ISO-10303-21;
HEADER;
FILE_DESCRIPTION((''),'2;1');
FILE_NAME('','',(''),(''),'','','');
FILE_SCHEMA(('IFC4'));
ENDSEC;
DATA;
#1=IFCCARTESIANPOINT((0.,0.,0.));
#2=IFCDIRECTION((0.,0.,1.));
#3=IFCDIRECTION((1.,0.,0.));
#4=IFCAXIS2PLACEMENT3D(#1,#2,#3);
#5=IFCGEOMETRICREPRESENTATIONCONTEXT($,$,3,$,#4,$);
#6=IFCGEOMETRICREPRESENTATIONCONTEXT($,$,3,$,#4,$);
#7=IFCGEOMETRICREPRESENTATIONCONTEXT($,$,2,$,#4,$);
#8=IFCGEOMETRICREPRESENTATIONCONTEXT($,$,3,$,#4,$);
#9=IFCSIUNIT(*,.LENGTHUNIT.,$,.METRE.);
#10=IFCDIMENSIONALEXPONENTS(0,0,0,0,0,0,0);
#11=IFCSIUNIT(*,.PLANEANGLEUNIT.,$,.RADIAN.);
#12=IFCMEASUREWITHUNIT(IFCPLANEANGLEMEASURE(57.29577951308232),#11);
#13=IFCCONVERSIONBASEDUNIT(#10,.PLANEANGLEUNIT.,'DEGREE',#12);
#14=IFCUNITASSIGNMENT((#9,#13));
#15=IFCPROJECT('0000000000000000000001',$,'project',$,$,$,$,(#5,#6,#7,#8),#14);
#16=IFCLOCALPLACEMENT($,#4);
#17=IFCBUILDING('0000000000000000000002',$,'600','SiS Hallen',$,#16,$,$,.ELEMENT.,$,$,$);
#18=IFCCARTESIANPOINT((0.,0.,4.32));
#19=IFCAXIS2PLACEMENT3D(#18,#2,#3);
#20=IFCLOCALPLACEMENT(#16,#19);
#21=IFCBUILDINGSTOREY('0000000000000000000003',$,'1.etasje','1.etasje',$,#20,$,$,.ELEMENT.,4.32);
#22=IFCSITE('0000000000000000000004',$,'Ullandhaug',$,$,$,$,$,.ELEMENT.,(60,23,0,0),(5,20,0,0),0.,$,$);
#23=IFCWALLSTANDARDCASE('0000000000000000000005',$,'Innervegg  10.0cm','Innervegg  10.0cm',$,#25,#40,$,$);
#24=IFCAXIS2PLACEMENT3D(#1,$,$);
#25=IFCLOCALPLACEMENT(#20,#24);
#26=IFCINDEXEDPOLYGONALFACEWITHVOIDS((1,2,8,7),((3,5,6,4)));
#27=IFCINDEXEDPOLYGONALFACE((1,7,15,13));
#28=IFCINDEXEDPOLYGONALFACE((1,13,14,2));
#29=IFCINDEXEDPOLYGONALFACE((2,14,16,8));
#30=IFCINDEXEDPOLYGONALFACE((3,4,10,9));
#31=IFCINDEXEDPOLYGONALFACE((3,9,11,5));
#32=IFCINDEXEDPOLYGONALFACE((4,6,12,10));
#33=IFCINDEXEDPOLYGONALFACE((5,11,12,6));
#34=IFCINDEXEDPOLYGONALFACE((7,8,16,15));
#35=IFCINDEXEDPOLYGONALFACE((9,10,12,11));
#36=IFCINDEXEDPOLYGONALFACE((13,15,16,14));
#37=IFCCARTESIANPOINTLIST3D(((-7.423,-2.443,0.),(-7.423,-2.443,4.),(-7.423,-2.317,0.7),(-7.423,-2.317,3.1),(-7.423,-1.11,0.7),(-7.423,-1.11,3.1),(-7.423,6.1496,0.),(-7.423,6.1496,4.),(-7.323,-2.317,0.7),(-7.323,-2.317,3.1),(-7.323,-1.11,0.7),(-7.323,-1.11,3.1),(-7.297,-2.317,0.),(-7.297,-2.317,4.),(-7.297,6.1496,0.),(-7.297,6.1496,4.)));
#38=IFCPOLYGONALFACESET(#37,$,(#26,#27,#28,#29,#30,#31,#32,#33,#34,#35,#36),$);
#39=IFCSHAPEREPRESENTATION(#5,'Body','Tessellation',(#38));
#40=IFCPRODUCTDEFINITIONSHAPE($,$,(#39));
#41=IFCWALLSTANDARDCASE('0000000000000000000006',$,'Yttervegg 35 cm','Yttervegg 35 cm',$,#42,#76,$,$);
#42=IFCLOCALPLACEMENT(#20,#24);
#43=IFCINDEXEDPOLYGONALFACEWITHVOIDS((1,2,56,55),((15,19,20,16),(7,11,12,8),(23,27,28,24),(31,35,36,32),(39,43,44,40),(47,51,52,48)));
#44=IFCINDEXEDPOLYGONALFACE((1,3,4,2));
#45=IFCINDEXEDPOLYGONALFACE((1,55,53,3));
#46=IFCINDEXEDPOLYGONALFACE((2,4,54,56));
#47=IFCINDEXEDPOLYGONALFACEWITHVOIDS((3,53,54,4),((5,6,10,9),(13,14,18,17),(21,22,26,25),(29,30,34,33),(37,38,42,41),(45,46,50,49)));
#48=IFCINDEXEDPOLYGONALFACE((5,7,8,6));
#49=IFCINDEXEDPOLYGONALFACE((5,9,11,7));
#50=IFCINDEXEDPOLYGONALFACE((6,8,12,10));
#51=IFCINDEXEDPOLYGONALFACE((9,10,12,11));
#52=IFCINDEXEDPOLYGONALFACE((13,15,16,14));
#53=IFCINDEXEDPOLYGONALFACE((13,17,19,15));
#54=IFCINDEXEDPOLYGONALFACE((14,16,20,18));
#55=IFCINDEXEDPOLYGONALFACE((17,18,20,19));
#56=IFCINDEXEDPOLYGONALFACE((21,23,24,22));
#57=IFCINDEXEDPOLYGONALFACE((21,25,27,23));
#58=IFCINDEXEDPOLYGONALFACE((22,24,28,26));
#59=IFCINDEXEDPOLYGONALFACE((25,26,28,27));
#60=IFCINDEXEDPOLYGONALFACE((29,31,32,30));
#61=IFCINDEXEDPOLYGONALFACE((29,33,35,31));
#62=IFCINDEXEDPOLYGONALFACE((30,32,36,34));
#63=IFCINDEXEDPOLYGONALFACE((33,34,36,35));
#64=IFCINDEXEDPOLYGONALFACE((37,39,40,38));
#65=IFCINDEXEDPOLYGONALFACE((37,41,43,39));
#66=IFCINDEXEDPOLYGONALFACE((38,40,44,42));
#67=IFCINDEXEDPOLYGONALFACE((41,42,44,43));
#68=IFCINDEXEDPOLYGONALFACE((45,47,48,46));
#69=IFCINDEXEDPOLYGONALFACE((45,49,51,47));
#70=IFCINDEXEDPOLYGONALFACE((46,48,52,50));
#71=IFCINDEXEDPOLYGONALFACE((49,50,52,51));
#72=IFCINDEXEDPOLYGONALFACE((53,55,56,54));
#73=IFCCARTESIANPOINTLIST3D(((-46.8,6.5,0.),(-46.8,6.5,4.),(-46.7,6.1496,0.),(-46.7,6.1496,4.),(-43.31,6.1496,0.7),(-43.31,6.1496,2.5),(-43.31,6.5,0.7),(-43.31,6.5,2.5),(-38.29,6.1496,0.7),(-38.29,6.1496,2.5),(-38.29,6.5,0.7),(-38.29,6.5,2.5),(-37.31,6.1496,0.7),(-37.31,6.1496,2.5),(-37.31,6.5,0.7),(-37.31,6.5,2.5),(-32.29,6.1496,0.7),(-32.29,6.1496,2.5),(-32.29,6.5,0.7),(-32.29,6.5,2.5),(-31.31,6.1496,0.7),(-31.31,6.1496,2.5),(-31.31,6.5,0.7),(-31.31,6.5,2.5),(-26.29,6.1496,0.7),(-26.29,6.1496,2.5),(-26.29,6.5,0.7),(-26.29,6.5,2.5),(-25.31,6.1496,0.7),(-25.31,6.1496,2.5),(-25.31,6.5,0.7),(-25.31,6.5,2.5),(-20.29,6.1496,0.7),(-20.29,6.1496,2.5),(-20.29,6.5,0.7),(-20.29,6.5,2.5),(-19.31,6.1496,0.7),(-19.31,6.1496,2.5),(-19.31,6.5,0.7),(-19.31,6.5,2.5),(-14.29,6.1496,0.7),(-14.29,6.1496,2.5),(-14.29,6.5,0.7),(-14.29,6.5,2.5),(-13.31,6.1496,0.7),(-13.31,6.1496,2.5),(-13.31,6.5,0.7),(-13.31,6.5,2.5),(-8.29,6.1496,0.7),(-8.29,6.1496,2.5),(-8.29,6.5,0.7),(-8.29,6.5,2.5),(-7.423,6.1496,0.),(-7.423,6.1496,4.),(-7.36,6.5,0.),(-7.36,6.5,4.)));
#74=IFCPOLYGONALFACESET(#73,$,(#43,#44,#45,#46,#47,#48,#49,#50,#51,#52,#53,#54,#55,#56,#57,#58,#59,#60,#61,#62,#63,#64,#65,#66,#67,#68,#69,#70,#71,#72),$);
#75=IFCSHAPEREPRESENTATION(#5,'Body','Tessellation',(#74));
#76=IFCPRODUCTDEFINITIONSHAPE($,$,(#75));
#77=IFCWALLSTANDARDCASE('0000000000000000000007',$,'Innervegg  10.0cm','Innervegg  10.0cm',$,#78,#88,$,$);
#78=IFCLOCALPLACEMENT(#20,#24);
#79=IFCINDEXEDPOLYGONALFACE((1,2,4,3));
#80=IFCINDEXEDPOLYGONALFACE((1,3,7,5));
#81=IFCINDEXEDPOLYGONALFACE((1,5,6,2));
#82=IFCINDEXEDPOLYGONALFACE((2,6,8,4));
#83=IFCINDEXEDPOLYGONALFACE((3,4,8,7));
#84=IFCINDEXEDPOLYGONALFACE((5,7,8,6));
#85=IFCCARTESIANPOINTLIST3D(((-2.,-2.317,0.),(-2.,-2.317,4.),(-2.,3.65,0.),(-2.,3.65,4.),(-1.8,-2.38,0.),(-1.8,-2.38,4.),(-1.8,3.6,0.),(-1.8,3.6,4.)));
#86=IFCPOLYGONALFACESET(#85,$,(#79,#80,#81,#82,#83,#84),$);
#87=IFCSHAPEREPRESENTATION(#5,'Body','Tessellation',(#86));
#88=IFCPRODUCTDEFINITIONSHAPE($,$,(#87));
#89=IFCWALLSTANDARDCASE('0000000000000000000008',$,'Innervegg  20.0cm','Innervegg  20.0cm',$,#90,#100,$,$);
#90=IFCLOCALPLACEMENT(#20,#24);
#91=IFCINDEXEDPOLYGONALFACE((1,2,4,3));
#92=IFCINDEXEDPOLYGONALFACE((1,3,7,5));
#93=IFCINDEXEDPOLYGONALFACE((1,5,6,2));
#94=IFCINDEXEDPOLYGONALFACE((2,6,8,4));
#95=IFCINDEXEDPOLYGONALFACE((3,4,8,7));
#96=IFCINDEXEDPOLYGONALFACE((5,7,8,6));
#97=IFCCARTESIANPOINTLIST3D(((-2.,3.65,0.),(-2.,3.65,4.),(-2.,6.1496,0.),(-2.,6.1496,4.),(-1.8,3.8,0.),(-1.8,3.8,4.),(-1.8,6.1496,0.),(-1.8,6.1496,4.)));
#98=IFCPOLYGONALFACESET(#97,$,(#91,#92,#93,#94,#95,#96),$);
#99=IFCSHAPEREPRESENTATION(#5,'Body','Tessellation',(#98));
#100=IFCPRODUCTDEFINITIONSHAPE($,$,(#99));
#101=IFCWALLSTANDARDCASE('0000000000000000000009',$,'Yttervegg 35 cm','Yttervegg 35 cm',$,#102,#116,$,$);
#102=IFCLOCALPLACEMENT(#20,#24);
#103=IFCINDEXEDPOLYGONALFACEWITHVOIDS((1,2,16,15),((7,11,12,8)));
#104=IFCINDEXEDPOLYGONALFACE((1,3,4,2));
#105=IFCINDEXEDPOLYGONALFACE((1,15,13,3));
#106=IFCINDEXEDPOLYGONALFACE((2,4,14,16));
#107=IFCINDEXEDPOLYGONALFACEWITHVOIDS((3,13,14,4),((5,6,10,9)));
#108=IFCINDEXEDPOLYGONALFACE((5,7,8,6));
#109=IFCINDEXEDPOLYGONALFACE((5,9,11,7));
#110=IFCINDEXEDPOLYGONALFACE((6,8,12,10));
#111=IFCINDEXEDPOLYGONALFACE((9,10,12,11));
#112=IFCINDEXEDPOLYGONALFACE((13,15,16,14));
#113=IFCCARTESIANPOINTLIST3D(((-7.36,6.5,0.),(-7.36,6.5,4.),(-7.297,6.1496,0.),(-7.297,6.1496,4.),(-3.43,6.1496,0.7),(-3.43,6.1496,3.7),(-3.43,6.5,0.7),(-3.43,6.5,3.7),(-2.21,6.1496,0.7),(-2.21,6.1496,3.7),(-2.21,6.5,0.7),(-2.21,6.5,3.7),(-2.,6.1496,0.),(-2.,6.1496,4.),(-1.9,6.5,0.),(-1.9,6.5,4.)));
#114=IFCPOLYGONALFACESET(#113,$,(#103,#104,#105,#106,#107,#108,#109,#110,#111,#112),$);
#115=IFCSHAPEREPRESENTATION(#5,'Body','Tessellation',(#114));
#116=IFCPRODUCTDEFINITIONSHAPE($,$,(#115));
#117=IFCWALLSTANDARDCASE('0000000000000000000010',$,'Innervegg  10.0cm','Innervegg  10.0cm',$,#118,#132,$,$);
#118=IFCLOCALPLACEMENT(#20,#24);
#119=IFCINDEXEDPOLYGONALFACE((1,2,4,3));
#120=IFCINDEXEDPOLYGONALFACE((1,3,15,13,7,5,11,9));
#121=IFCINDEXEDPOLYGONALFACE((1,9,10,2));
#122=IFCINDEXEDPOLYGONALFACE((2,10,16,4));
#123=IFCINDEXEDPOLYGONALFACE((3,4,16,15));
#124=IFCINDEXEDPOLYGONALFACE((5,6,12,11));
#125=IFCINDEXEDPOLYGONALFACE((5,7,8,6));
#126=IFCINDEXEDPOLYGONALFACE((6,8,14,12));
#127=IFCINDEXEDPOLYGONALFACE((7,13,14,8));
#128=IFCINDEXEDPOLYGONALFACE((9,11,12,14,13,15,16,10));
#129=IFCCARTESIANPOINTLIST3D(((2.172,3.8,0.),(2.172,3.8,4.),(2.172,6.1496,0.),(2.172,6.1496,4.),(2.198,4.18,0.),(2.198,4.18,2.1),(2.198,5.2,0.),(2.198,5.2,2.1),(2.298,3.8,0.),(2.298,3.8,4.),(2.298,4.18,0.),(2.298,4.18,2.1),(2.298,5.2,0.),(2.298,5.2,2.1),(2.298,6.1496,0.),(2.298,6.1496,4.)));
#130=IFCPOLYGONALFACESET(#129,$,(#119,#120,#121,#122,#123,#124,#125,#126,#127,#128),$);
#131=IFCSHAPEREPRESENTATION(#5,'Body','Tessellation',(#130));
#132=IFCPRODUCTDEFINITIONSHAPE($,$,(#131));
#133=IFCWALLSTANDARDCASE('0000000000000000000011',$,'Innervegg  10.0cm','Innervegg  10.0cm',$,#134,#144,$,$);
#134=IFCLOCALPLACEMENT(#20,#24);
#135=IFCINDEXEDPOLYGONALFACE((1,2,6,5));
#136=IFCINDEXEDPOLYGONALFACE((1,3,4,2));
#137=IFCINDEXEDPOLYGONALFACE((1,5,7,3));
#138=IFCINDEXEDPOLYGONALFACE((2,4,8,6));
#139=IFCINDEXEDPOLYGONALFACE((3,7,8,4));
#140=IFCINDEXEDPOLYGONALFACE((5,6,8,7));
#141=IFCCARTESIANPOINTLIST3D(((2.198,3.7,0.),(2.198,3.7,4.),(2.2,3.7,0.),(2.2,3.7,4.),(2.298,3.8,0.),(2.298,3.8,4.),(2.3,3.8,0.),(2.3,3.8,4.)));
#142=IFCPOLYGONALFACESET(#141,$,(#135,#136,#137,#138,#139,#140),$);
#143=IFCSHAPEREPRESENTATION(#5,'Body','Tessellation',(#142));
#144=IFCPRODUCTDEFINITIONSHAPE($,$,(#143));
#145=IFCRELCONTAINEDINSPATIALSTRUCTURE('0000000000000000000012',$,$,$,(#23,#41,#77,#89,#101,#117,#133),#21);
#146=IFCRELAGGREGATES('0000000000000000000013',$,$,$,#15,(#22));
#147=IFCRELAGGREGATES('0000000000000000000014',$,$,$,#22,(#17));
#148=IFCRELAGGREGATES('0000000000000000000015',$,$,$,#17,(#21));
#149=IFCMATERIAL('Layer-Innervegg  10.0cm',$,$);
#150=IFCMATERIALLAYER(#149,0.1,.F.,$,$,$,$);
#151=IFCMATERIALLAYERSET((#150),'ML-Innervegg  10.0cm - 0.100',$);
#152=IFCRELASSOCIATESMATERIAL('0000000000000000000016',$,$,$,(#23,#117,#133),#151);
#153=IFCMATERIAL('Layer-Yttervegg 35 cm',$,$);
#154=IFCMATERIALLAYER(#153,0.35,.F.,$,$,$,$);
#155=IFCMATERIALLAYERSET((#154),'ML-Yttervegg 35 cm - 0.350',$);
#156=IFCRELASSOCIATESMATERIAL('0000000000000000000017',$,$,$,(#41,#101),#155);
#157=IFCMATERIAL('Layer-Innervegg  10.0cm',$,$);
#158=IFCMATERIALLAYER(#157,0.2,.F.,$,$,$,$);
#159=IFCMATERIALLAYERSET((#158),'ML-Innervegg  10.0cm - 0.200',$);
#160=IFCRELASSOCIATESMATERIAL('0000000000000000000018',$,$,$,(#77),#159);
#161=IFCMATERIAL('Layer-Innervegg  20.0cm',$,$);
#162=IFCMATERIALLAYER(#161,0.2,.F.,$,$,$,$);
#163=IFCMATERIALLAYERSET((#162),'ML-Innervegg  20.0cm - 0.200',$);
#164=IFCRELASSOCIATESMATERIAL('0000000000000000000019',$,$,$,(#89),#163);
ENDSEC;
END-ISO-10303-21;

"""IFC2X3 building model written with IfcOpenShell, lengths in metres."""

from ifc_helpers import new_model, entity, si_unit, converted_unit, frame, origin_with_axes, place, context, project, spatial, polyline, outline, extrude, material, layer, layer_set, layer_usage, element, save


model = new_model("IFC2X3")

# Units and contexts
context_of_model_1 = context(None, 3, world=origin_with_axes())
context_of_model_2 = context(None, 3, world=origin_with_axes())
context_of_model_3 = context(None, 2, world=origin_with_axes())
context_of_model_4 = context(None, 3, world=origin_with_axes())
ifc_project = project(units=[si_unit("LENGTHUNIT", "METRE"), converted_unit("PLANEANGLEUNIT", "DEGREE", entity("IfcPlaneAngleMeasure", 57.29577951308232), si_unit("PLANEANGLEUNIT", "RADIAN"), dimensions=[0, 0, 0, 0, 0, 0, 0])], contexts=[context_of_model_1, context_of_model_2, context_of_model_3, context_of_model_4])

# Site, building, storey
site = spatial("IfcSite", under=ifc_project, Name="Ullandhaug", CompositionType="ELEMENT", RefLatitude=(60, 23, 0, 0), RefLongitude=(5, 20, 0, 0), RefElevation=0.0)
building_placement = place(None, origin_with_axes())
building = spatial("IfcBuilding", under=site, at=building_placement, Name="600", Description="SiS Hallen", CompositionType="ELEMENT")
storey_placement = place(building_placement, frame((0.0, 0.0, 4.32), z_axis=(0.0, 0.0, 1.0), x_axis=(1.0, 0.0, 0.0)))
storey = spatial("IfcBuildingStorey", under=building, at=storey_placement, Name="1.etasje", Description="1.etasje", CompositionType="ELEMENT", Elevation=4.32)

# Shared definitions
ifc_material_1 = material(Name="Layer-Innervegg  20.0cm")
ifc_layer_1 = layer(ifc_material_1, 0.2, ventilated=False)
ifc_layer_set_1 = layer_set([ifc_layer_1], Name="ML-Innervegg  20.0cm - 0.200")
ifc_layer_usage_1 = layer_usage(ifc_layer_set_1, "AXIS2", "POSITIVE", 0.0)

# Wall, opening
ifc_material_2 = material(Name="Layer-Innervegg  10.0cm")
ifc_layer_2 = layer(ifc_material_2, 0.1, ventilated=False)
ifc_layer_set_2 = layer_set([ifc_layer_2], Name="ML-Innervegg  10.0cm - 0.100")
ifc_layer_usage_2 = layer_usage(ifc_layer_set_2, "AXIS2", "POSITIVE", 0.0)
wall_1_placement = place(storey_placement, frame((-7.297, -2.317, 0.0), z_axis=(0.0, 0.0, 1.0), x_axis=(0.0, 1.0, 0.0)))
wall_1 = element("IfcWallStandardCase", 1, at=wall_1_placement, inside=storey, material=ifc_layer_usage_2, Name="Innervegg  10.0cm", Description="Innervegg  10.0cm", context=context_of_model_1, shape_type="SweptSolid", body=[
    extrude(outline(polyline([(0.0, 0.0), (8.4666, 0.0), (8.4666, 0.126), (-0.126, 0.126), (0.0, 0.0)])), frame((0.0, 0.0, 0.0), z_axis=(0.0, 0.0, 1.0), x_axis=(1.0, 0.0, 0.0)), (0.0, 0.0, 1.0), 4.0),
])
opening_1_placement = place(wall_1_placement, frame((0.0, 0.126, 0.7), z_axis=(0.0, 0.0, 1.0), x_axis=(1.0, 0.0, 0.0)))
element("IfcOpeningElement", 2, at=opening_1_placement, cuts=wall_1, context=context_of_model_1, shape_type="SweptSolid", body=[
    extrude(outline(polyline([(0.0, 0.0), (2.4, 0.0), (2.4, 1.207), (0.0, 1.207), (0.0, 0.0)])), frame((0.0, 0.0, 0.0), z_axis=(0.0, 1.0, 0.0), x_axis=(0.0, 0.0, 1.0)), (0.0, 0.0, -1.0), 0.1),
])

# Wall, openings
ifc_material_3 = material(Name="Layer-Yttervegg 35 cm")
ifc_layer_3 = layer(ifc_material_3, 0.35, ventilated=False)
ifc_layer_set_3 = layer_set([ifc_layer_3], Name="ML-Yttervegg 35 cm - 0.350")
ifc_layer_usage_3 = layer_usage(ifc_layer_set_3, "AXIS2", "POSITIVE", 0.0)
wall_2_placement = place(storey_placement, frame((-7.36, 6.5, 0.0), z_axis=(0.0, 0.0, 1.0), x_axis=(-1.0, 0.0, 0.0)))
wall_2 = element("IfcWallStandardCase", 3, at=wall_2_placement, inside=storey, material=ifc_layer_usage_3, Name="Yttervegg 35 cm", Description="Yttervegg 35 cm", context=context_of_model_1, shape_type="SweptSolid", body=[
    extrude(outline(polyline([(0.0, 0.0), (39.44, 0.0), (39.34, 0.3504), (0.063, 0.3504), (0.0, 0.0)])), frame((0.0, 0.0, 0.0), z_axis=(0.0, 0.0, 1.0), x_axis=(1.0, 0.0, 0.0)), (0.0, 0.0, 1.0), 4.0),
])
opening_2_placement = place(wall_2_placement, frame((0.93, 0.3504, 0.7), z_axis=(0.0, 0.0, 1.0), x_axis=(1.0, 0.0, 0.0)))
element("IfcOpeningElement", 4, at=opening_2_placement, cuts=wall_2, context=context_of_model_1, shape_type="SweptSolid", body=[
    extrude(outline(polyline([(0.0, 0.0), (1.8, 0.0), (1.8, 5.02), (0.0, 5.02), (0.0, 0.0)])), frame((0.0, 0.0, 0.0), z_axis=(0.0, 1.0, 0.0), x_axis=(0.0, 0.0, 1.0)), (0.0, 0.0, -1.0), 0.3504),
])
opening_3_placement = place(wall_2_placement, frame((6.93, 0.3504, 0.7), z_axis=(0.0, 0.0, 1.0), x_axis=(1.0, 0.0, 0.0)))
element("IfcOpeningElement", 5, at=opening_3_placement, cuts=wall_2, context=context_of_model_1, shape_type="SweptSolid", body=[
    extrude(outline(polyline([(0.0, 0.0), (1.8, 0.0), (1.8, 5.02), (0.0, 5.02), (0.0, 0.0)])), frame((0.0, 0.0, 0.0), z_axis=(0.0, 1.0, 0.0), x_axis=(0.0, 0.0, 1.0)), (0.0, 0.0, -1.0), 0.3504),
])
opening_4_placement = place(wall_2_placement, frame((12.93, 0.3504, 0.7), z_axis=(0.0, 0.0, 1.0), x_axis=(1.0, 0.0, 0.0)))
element("IfcOpeningElement", 6, at=opening_4_placement, cuts=wall_2, context=context_of_model_1, shape_type="SweptSolid", body=[
    extrude(outline(polyline([(0.0, 0.0), (1.8, 0.0), (1.8, 5.02), (0.0, 5.02), (0.0, 0.0)])), frame((0.0, 0.0, 0.0), z_axis=(0.0, 1.0, 0.0), x_axis=(0.0, 0.0, 1.0)), (0.0, 0.0, -1.0), 0.3504),
])
opening_5_placement = place(wall_2_placement, frame((18.93, 0.3504, 0.7), z_axis=(0.0, 0.0, 1.0), x_axis=(1.0, 0.0, 0.0)))
element("IfcOpeningElement", 7, at=opening_5_placement, cuts=wall_2, context=context_of_model_1, shape_type="SweptSolid", body=[
    extrude(outline(polyline([(0.0, 0.0), (1.8, 0.0), (1.8, 5.02), (0.0, 5.02), (0.0, 0.0)])), frame((0.0, 0.0, 0.0), z_axis=(0.0, 1.0, 0.0), x_axis=(0.0, 0.0, 1.0)), (0.0, 0.0, -1.0), 0.3504),
])
opening_6_placement = place(wall_2_placement, frame((24.93, 0.3504, 0.7), z_axis=(0.0, 0.0, 1.0), x_axis=(1.0, 0.0, 0.0)))
element("IfcOpeningElement", 8, at=opening_6_placement, cuts=wall_2, context=context_of_model_1, shape_type="SweptSolid", body=[
    extrude(outline(polyline([(0.0, 0.0), (1.8, 0.0), (1.8, 5.02), (0.0, 5.02), (0.0, 0.0)])), frame((0.0, 0.0, 0.0), z_axis=(0.0, 1.0, 0.0), x_axis=(0.0, 0.0, 1.0)), (0.0, 0.0, -1.0), 0.3504),
])
opening_7_placement = place(wall_2_placement, frame((30.93, 0.3504, 0.7), z_axis=(0.0, 0.0, 1.0), x_axis=(1.0, 0.0, 0.0)))
element("IfcOpeningElement", 9, at=opening_7_placement, cuts=wall_2, context=context_of_model_1, shape_type="SweptSolid", body=[
    extrude(outline(polyline([(0.0, 0.0), (1.8, 0.0), (1.8, 5.02), (0.0, 5.02), (0.0, 0.0)])), frame((0.0, 0.0, 0.0), z_axis=(0.0, 1.0, 0.0), x_axis=(0.0, 0.0, 1.0)), (0.0, 0.0, -1.0), 0.3504),
])

# Walls
ifc_material_4 = material(Name="Layer-Innervegg  10.0cm")
ifc_layer_4 = layer(ifc_material_4, 0.2, ventilated=False)
ifc_layer_set_4 = layer_set([ifc_layer_4], Name="ML-Innervegg  10.0cm - 0.200")
ifc_layer_usage_4 = layer_usage(ifc_layer_set_4, "AXIS2", "POSITIVE", 0.0)
wall_3_placement = place(storey_placement, frame((-1.8, -2.38, 0.0), z_axis=(0.0, 0.0, 1.0), x_axis=(0.0, 1.0, 0.0)))
element("IfcWallStandardCase", 10, at=wall_3_placement, inside=storey, material=ifc_layer_usage_4, Name="Innervegg  10.0cm", Description="Innervegg  10.0cm", context=context_of_model_1, shape_type="SweptSolid", body=[
    extrude(outline(polyline([(0.0, 0.0), (5.98, 0.0), (6.03, 0.2), (0.063, 0.2), (0.0, 0.0)])), frame((0.0, 0.0, 0.0), z_axis=(0.0, 0.0, 1.0), x_axis=(1.0, 0.0, 0.0)), (0.0, 0.0, 1.0), 4.0),
])
wall_4_placement = place(storey_placement, frame((-1.8, 3.8, 0.0), z_axis=(0.0, 0.0, 1.0), x_axis=(0.0, 1.0, 0.0)))
element("IfcWallStandardCase", 11, at=wall_4_placement, inside=storey, material=ifc_layer_usage_1, Name="Innervegg  20.0cm", Description="Innervegg  20.0cm", context=context_of_model_1, shape_type="SweptSolid", body=[
    extrude(outline(polyline([(0.0, 0.0), (2.3496, 0.0), (2.3496, 0.2), (-0.15, 0.2), (0.0, 0.0)])), frame((0.0, 0.0, 0.0), z_axis=(0.0, 0.0, 1.0), x_axis=(1.0, 0.0, 0.0)), (0.0, 0.0, 1.0), 4.0),
])

# Walls, openings
wall_5_placement = place(storey_placement, frame((-1.9, 6.5, 0.0), z_axis=(0.0, 0.0, 1.0), x_axis=(-1.0, 0.0, 0.0)))
wall_5 = element("IfcWallStandardCase", 12, at=wall_5_placement, inside=storey, material=ifc_layer_usage_3, Name="Yttervegg 35 cm", Description="Yttervegg 35 cm", context=context_of_model_1, shape_type="SweptSolid", body=[
    extrude(outline(polyline([(0.0, 0.0), (5.46, 0.0), (5.397, 0.3504), (0.1, 0.3504), (0.0, 0.0)])), frame((0.0, 0.0, 0.0), z_axis=(0.0, 0.0, 1.0), x_axis=(1.0, 0.0, 0.0)), (0.0, 0.0, 1.0), 4.0),
])
opening_8_placement = place(wall_5_placement, frame((0.31, 0.3504, 0.7), z_axis=(0.0, 0.0, 1.0), x_axis=(1.0, 0.0, 0.0)))
element("IfcOpeningElement", 13, at=opening_8_placement, cuts=wall_5, context=context_of_model_1, shape_type="SweptSolid", body=[
    extrude(outline(polyline([(0.0, 0.0), (3.0, 0.0), (3.0, 1.22), (0.0, 1.22), (0.0, 0.0)])), frame((0.0, 0.0, 0.0), z_axis=(0.0, 1.0, 0.0), x_axis=(0.0, 0.0, 1.0)), (0.0, 0.0, -1.0), 0.3504),
])
wall_6_placement = place(storey_placement, frame((2.172, 6.1496, 0.0), z_axis=(0.0, 0.0, 1.0), x_axis=(0.0, -1.0, 0.0)))
wall_6 = element("IfcWallStandardCase", 14, at=wall_6_placement, inside=storey, material=ifc_layer_usage_2, Name="Innervegg  10.0cm", Description="Innervegg  10.0cm", context=context_of_model_1, shape_type="SweptSolid", body=[
    extrude(outline(polyline([(0.0, 0.0), (2.3496, 0.0), (2.3496, 0.126), (0.0, 0.126), (0.0, 0.0)])), frame((0.0, 0.0, 0.0), z_axis=(0.0, 0.0, 1.0), x_axis=(1.0, 0.0, 0.0)), (0.0, 0.0, 1.0), 4.0),
])
opening_9_placement = place(wall_6_placement, frame((0.9496, 0.126, 0.0), z_axis=(0.0, 0.0, 1.0), x_axis=(1.0, 0.0, 0.0)))
element("IfcOpeningElement", 15, at=opening_9_placement, cuts=wall_6, context=context_of_model_1, shape_type="SweptSolid", body=[
    extrude(outline(polyline([(0.0, 0.0), (2.1, 0.0), (2.1, 1.02), (0.0, 1.02), (0.0, 0.0)])), frame((0.0, 0.0, 0.0), z_axis=(0.0, 1.0, 0.0), x_axis=(0.0, 0.0, 1.0)), (0.0, 0.0, -1.0), 0.1),
])

# Wall
wall_7_placement = place(storey_placement, frame((2.198, 3.7, 0.0), z_axis=(0.0, 0.0, 1.0), x_axis=(1.0, 0.0, 0.0)))
element("IfcWallStandardCase", 16, at=wall_7_placement, inside=storey, material=ifc_layer_usage_2, Name="Innervegg  10.0cm", Description="Innervegg  10.0cm", context=context_of_model_1, shape_type="SweptSolid", body=[
    extrude(outline(polyline([(0.0, 0.0), (0.002, 0.0), (0.102, 0.1), (0.1, 0.1), (0.0, 0.0)])), origin_with_axes(), (0.0, 0.0, 1.0), 4.0),
])

save(model, "model.ifc")
